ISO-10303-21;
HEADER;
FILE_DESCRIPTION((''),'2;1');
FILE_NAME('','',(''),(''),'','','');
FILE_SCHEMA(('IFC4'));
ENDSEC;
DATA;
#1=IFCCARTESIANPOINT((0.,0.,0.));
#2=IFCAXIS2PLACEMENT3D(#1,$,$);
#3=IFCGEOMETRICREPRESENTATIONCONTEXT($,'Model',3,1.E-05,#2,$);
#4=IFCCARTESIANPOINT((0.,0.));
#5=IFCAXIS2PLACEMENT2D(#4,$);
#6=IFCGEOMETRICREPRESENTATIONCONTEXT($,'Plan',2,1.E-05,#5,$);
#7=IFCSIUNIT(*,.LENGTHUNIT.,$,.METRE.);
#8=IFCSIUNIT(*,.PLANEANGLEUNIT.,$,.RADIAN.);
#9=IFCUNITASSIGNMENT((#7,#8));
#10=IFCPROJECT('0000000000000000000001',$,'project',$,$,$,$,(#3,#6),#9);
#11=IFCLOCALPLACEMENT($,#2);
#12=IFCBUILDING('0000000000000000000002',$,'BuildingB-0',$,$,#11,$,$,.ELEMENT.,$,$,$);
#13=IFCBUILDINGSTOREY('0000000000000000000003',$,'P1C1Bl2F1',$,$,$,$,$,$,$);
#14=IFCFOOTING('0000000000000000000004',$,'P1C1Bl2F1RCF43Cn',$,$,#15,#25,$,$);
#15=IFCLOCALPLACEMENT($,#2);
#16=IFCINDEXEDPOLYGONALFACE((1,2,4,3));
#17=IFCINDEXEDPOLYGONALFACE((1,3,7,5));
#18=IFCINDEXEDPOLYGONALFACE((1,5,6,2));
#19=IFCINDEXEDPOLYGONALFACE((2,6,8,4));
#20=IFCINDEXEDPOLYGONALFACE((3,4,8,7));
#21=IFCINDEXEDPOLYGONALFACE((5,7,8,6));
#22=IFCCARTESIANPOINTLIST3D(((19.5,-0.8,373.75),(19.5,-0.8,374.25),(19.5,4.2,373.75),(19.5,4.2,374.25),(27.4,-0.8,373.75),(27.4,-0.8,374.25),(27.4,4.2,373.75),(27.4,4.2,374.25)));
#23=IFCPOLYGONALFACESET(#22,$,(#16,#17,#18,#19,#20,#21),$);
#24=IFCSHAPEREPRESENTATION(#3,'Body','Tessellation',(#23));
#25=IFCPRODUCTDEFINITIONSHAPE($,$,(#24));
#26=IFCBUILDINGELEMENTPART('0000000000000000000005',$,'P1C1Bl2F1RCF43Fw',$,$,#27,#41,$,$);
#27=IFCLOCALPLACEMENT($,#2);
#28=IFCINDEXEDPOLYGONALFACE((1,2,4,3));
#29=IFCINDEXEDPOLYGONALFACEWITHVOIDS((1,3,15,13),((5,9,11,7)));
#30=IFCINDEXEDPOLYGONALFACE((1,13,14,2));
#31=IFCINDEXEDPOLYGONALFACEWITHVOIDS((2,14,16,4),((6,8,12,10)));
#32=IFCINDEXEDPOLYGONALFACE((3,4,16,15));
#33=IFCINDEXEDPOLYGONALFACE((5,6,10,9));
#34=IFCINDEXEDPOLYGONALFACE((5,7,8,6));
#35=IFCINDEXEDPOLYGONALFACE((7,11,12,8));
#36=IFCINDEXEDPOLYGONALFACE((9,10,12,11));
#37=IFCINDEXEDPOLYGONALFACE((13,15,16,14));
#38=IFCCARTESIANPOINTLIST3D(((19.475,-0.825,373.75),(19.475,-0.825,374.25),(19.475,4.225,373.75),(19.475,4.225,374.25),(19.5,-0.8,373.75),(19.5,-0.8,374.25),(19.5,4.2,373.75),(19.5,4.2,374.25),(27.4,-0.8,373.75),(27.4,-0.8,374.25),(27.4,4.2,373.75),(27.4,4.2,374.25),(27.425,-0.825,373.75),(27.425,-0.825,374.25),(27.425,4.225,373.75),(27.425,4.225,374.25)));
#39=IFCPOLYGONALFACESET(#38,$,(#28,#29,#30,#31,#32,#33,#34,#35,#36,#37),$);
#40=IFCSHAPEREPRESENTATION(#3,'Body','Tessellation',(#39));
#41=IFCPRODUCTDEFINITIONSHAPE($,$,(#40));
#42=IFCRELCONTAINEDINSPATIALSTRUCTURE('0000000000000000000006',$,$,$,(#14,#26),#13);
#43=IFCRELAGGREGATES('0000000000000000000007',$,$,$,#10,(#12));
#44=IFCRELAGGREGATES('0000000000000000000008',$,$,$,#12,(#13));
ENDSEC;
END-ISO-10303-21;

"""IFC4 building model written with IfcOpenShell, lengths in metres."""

from ifc_helpers import new_model, si_unit, origin, origin_2d, place, context, project, spatial, polyline, outline, extrude, element, save


model = new_model("IFC4")

# Units and contexts
model_context = context("Model", 3, precision=1e-05, world=origin())
plan_context = context("Plan", 2, precision=1e-05, world=origin_2d())
ifc_project = project(units=[si_unit("LENGTHUNIT", "METRE"), si_unit("PLANEANGLEUNIT", "RADIAN")], contexts=[model_context, plan_context])

# Building, storey
building_placement = place(None, origin())
building = spatial("IfcBuilding", under=ifc_project, at=building_placement, Name="BuildingB-0", CompositionType="ELEMENT")
storey = spatial("IfcBuildingStorey", under=building, Name="P1C1Bl2F1")

# Footing
element("IfcFooting", 1, inside=storey, Name="P1C1Bl2F1RCF43Cn", context=model_context, shape_type="SweptSolid", body=[
    extrude(outline(polyline([(27.4, 4.2, 373.75), (19.5, 4.2, 373.75), (19.5, -0.8, 373.75), (27.4, -0.8, 373.75), (27.4, 4.2, 373.75)])), None, (0.0, 0.0, 1.0), 0.5),
])

# Building element part, opening
building_element_part = element("IfcBuildingElementPart", 2, inside=storey, Name="P1C1Bl2F1RCF43Fw", context=model_context, shape_type="SweptSolid", body=[
    extrude(outline(polyline([(27.425, 4.225, 373.75), (19.475, 4.225, 373.75), (19.475, -0.825, 373.75), (27.425, -0.825, 373.75), (27.425, 4.225, 373.75)])), None, (0.0, 0.0, 1.0), 0.5),
])
element("IfcOpeningElement", 3, inside=storey, cuts=building_element_part, context=model_context, shape_type="SweptSolid", body=[
    extrude(outline(polyline([(27.4, 4.2, 373.75), (19.5, 4.2, 373.75), (19.5, -0.8, 373.75), (27.4, -0.8, 373.75), (27.4, 4.2, 373.75)])), None, (0.0, 0.0, 1.0), 0.5),
])

save(model, "model.ifc")
